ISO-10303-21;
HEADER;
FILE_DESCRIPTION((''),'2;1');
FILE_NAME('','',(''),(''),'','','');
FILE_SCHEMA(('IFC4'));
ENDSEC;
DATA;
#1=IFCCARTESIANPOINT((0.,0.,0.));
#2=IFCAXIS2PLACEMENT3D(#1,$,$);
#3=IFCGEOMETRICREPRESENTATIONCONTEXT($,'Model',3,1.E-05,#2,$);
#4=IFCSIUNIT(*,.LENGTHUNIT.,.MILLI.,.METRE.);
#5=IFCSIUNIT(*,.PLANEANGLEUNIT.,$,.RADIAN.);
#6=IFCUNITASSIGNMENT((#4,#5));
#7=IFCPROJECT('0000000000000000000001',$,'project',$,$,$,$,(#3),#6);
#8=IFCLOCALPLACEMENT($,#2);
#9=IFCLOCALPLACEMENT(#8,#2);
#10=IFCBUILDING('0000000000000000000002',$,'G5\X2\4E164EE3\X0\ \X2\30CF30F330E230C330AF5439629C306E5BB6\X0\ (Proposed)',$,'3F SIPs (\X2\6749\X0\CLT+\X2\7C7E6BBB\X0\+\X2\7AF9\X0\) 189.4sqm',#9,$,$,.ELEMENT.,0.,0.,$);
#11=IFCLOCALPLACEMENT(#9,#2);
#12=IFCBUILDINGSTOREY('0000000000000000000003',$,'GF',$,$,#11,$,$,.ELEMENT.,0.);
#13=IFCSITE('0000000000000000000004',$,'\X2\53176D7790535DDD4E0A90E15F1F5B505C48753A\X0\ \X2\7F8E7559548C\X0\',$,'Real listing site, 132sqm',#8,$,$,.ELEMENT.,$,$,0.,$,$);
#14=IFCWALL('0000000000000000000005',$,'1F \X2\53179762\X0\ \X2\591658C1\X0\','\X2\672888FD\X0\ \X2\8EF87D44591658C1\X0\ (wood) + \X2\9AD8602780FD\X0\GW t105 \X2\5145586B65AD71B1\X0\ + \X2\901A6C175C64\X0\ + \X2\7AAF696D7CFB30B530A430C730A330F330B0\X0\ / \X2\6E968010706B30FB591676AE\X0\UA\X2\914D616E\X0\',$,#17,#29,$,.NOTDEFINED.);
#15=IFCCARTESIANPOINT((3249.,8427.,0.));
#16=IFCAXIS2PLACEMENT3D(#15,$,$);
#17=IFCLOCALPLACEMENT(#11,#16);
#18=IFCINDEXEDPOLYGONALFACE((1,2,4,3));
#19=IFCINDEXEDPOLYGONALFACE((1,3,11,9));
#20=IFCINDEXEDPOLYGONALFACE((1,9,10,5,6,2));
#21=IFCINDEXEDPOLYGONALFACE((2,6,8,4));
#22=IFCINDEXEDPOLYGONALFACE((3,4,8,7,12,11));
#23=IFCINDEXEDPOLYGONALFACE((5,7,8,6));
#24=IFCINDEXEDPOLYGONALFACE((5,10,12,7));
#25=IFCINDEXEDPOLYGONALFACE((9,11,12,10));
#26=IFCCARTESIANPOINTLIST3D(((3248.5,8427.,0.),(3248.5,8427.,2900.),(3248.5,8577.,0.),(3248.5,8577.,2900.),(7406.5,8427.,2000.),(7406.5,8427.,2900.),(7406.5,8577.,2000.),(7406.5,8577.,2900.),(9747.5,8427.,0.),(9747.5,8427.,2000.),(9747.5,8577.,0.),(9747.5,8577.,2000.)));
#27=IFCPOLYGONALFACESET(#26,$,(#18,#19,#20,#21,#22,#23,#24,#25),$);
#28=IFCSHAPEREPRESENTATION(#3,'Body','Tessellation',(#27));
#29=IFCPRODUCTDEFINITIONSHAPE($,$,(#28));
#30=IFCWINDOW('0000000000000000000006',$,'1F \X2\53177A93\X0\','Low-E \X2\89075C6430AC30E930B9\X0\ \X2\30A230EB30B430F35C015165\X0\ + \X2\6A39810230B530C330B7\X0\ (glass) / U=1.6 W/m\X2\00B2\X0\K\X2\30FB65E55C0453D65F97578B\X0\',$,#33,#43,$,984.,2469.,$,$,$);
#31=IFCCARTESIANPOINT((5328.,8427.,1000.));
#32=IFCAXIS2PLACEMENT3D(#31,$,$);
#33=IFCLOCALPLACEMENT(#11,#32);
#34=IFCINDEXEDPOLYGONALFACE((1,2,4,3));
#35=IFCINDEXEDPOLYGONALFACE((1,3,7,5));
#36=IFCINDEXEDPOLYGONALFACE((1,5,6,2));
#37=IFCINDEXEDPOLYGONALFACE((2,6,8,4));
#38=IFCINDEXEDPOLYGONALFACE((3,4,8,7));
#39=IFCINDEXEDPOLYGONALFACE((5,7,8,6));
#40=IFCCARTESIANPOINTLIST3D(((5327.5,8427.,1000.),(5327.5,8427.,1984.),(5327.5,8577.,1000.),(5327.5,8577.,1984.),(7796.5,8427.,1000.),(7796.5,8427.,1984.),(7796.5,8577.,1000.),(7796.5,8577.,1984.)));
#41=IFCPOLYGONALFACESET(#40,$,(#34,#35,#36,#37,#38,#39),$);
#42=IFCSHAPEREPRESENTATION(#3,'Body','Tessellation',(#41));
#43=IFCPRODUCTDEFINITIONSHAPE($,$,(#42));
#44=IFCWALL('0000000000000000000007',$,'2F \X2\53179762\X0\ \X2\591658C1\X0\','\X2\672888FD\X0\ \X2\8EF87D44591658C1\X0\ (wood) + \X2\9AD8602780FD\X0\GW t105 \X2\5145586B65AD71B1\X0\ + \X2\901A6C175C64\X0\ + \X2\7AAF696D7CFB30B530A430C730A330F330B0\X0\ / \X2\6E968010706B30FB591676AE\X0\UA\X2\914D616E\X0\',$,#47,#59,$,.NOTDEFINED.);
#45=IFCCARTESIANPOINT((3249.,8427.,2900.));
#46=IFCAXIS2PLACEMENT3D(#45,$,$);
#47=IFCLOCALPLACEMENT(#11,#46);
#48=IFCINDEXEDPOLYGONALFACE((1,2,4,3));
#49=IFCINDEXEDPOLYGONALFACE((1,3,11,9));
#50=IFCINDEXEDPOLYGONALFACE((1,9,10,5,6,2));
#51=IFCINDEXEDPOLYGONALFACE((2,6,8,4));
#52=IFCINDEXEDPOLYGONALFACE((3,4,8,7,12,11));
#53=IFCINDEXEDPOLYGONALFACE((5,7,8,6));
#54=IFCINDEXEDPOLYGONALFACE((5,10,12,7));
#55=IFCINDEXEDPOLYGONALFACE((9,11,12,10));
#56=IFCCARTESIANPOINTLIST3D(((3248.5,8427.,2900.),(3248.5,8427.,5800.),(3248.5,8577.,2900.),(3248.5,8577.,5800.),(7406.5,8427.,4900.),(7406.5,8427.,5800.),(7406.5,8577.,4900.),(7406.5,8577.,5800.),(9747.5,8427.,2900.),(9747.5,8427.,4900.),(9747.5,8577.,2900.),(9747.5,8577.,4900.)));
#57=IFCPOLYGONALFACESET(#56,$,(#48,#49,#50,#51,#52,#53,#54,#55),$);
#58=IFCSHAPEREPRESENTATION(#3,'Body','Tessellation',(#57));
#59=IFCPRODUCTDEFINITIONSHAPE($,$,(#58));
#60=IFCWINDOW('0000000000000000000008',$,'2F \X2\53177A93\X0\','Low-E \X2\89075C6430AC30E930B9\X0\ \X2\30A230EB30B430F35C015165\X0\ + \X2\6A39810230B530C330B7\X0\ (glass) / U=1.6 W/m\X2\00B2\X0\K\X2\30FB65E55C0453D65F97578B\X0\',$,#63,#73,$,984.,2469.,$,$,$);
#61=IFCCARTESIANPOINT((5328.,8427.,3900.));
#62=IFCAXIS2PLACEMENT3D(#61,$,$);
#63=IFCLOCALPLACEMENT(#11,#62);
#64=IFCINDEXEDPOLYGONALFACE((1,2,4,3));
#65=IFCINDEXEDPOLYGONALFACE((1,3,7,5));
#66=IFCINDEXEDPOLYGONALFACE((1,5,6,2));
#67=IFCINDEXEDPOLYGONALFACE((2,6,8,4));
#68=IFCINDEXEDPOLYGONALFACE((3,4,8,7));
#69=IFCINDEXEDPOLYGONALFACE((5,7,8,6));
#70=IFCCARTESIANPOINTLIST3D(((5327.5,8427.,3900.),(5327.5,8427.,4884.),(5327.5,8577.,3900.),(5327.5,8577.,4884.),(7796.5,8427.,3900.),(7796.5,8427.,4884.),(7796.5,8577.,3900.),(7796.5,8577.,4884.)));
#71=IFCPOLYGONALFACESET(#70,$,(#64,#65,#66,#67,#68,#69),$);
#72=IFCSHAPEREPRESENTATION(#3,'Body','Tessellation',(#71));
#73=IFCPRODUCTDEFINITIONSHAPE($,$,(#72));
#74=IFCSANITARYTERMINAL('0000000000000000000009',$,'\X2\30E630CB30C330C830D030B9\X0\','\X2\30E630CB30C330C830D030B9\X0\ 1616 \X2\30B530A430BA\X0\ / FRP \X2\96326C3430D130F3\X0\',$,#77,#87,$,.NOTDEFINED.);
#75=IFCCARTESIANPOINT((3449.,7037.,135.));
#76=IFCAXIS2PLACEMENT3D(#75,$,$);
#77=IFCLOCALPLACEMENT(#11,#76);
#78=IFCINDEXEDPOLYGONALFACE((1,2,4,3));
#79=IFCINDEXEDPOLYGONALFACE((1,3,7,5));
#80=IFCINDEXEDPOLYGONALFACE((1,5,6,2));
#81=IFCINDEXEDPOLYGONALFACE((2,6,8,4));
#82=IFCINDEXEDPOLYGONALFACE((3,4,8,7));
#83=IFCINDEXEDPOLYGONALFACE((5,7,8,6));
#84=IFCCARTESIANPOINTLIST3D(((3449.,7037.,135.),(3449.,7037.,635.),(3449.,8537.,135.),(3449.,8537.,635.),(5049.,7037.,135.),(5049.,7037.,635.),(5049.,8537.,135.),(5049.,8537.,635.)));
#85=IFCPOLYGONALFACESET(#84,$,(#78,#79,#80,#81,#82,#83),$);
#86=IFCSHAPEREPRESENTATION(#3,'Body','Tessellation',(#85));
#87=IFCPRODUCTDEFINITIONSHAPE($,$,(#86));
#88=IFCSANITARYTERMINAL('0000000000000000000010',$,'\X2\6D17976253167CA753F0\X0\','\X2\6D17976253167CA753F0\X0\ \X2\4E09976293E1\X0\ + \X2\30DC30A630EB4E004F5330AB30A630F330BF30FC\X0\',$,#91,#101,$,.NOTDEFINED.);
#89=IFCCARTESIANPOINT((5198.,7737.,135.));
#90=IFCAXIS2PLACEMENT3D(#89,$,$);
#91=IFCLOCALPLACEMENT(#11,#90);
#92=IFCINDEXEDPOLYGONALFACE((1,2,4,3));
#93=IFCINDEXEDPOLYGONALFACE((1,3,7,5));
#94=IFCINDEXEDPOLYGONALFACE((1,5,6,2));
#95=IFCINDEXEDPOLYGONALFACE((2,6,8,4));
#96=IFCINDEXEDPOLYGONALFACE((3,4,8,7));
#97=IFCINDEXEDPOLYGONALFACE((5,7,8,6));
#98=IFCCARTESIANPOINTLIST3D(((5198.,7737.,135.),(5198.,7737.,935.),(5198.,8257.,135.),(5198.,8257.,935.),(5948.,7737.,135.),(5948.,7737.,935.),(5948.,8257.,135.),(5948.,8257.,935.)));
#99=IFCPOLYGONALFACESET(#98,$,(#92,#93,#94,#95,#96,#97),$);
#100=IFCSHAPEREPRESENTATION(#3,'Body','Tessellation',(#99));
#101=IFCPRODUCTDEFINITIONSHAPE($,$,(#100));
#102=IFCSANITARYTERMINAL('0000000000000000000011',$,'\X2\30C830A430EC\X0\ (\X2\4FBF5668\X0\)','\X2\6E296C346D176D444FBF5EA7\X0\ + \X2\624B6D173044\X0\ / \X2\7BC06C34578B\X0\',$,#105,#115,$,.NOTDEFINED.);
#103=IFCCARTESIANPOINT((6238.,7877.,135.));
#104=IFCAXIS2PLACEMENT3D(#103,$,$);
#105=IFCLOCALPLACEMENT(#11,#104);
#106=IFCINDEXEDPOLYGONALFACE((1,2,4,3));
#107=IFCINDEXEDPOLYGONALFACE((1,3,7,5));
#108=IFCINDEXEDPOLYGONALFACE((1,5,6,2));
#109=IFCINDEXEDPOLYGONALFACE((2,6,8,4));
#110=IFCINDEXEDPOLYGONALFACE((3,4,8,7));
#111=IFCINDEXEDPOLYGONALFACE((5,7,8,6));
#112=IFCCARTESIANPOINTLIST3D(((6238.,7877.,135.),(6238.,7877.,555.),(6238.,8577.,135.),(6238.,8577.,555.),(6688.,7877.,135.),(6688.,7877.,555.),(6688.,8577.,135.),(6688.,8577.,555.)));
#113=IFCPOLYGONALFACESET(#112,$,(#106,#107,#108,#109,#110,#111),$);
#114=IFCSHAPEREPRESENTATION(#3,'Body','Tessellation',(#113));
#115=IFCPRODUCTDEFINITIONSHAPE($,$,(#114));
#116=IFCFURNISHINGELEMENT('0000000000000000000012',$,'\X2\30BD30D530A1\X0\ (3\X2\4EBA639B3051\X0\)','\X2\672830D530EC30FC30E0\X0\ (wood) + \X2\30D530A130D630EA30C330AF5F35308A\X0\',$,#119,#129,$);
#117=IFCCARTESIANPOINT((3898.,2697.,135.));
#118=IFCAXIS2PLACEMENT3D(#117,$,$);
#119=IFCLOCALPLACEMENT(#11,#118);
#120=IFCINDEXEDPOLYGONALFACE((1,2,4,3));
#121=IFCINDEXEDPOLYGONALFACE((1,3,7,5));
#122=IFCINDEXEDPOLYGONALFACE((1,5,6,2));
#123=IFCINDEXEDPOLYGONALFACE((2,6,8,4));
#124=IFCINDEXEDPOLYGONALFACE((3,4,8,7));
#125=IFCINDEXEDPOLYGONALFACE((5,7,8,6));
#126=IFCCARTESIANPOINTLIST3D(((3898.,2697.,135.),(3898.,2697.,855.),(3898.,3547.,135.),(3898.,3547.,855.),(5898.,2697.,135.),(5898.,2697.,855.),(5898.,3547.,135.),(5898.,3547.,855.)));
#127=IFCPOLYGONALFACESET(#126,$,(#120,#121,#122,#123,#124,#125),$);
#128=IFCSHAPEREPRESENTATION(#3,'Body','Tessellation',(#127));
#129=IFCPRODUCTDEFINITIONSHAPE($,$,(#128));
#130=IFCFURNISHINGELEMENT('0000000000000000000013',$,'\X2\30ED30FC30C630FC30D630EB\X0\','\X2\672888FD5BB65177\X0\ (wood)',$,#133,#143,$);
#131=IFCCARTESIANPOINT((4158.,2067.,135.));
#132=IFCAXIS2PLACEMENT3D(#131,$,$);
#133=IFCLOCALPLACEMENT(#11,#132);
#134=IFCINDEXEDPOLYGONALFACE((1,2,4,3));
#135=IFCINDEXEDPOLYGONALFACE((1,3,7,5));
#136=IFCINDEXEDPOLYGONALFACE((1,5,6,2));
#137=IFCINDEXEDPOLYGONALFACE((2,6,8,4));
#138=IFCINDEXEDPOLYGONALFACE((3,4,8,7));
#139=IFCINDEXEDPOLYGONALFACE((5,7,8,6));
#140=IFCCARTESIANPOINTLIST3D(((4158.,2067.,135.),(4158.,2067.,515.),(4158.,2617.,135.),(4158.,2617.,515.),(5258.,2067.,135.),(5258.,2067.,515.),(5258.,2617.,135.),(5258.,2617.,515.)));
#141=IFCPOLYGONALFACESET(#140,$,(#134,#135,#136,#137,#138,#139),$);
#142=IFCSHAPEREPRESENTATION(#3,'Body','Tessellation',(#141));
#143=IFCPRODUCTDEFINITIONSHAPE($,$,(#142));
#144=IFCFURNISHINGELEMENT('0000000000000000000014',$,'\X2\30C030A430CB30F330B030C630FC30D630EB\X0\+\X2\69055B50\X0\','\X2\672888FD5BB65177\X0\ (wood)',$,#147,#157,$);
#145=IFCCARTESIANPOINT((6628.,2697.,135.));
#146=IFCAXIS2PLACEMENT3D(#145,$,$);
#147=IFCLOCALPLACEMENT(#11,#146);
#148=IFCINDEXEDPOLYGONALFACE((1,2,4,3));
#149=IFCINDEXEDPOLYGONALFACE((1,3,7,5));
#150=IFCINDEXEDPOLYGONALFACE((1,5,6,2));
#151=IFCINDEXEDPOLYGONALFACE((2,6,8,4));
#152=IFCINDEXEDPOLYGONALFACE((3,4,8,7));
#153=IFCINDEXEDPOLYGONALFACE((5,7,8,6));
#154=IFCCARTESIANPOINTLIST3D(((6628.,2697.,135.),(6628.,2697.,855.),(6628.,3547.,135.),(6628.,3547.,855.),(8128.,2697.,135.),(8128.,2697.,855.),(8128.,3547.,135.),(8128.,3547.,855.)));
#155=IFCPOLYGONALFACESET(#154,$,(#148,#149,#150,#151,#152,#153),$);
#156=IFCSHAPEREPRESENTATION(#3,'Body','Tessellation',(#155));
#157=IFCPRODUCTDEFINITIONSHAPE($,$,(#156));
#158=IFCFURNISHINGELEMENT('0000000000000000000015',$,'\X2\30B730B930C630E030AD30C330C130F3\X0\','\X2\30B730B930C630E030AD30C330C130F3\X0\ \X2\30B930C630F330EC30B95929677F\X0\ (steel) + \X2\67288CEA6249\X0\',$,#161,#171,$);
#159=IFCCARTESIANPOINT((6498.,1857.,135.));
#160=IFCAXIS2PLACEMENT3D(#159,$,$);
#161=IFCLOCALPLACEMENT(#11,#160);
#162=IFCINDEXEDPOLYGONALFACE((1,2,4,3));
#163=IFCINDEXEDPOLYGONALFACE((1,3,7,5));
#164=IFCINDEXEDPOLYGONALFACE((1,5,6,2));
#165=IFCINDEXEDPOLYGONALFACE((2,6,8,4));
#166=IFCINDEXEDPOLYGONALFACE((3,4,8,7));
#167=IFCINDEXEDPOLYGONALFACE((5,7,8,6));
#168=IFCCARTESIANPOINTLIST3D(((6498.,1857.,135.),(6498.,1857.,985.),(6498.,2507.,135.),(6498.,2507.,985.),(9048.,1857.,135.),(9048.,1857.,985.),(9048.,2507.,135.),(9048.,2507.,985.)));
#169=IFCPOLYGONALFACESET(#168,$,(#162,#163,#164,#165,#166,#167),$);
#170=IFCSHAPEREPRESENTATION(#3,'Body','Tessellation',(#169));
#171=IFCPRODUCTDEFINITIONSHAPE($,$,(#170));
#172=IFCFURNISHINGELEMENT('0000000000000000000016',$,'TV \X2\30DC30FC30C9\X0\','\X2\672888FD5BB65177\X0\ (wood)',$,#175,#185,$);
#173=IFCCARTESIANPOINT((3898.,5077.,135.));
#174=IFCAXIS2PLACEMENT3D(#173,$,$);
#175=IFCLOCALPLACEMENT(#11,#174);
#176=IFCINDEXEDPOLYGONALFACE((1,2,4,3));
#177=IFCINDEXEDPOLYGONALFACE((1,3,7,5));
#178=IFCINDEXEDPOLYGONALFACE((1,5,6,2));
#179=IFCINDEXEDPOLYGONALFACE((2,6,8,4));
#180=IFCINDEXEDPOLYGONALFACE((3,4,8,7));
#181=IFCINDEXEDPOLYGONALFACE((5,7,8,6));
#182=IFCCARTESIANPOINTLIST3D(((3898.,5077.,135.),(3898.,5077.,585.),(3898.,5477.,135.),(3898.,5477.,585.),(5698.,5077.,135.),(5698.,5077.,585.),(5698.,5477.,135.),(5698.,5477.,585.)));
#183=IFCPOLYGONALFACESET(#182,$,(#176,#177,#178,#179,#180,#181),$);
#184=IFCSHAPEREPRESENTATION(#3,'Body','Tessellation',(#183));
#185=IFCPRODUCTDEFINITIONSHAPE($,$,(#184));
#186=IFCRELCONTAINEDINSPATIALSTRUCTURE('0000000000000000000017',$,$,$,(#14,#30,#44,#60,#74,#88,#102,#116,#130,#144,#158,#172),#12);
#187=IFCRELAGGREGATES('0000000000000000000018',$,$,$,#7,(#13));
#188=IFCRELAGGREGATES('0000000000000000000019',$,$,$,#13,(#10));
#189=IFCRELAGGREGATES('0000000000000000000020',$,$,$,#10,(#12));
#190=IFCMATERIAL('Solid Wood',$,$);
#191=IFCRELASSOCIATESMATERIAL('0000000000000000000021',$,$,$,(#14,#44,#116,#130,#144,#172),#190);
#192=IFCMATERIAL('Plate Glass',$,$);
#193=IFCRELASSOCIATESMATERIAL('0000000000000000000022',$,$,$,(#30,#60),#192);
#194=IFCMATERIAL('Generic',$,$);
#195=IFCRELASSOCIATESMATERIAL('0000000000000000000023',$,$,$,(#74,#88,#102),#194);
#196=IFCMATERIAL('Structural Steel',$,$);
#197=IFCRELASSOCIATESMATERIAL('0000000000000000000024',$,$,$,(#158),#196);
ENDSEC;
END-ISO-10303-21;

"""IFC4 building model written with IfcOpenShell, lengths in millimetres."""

from ifc_helpers import new_model, si_unit, frame, frame_2d, origin, place, context, project, spatial, rectangle, extrude, material, element, fill, save


model = new_model("IFC4")

# Units and contexts
model_context = context("Model", 3, precision=1e-05, world=origin())
ifc_project = project(units=[si_unit("LENGTHUNIT", "METRE", prefix="MILLI"), si_unit("PLANEANGLEUNIT", "RADIAN")], contexts=[model_context])

# Site, building, storey
site_placement = place(None, origin())
site = spatial("IfcSite", under=ifc_project, at=site_placement, Name="北海道川上郡弟子屈町 美留和", ObjectType="Real listing site, 132sqm", CompositionType="ELEMENT", RefElevation=0.0)
building_placement = place(site_placement, origin())
building = spatial("IfcBuilding", under=site, at=building_placement, Name="G5世代 ハンモック吹抜の家 (Proposed)", ObjectType="3F SIPs (杉CLT+籾殻+竹) 189.4sqm", CompositionType="ELEMENT", ElevationOfRefHeight=0.0, ElevationOfTerrain=0.0)
storey_placement = place(building_placement, origin())
storey = spatial("IfcBuildingStorey", under=building, at=storey_placement, Name="GF", CompositionType="ELEMENT", Elevation=0.0)

# Wall, opening, window
ifc_material_1 = material(Name="Solid Wood")
wall_1_placement = place(storey_placement, frame((3249.0, 8427.0, 0.0)))
wall_1 = element("IfcWall", 1, at=wall_1_placement, inside=storey, material=ifc_material_1, Name="1F 北面 外壁", Description="木製 軸組外壁 (wood) + 高性能GW t105 充填断熱 + 通気層 + 窯業系サイディング / 準耐火・外皮UA配慮", PredefinedType="NOTDEFINED", context=model_context, shape_type="SweptSolid", body=[
    extrude(rectangle(XDim=6499.0, YDim=150.0, at=frame_2d((3249.0, 75.0))), frame((3249.0, 8427.0, 0.0)), (0.0, 0.0, 1.0), 2900.0),
])
opening_1_placement = place(storey_placement, frame((5328.0, 8427.0, 1000.0)))
opening_1 = element("IfcOpeningElement", 2, at=opening_1_placement, cuts=wall_1, PredefinedType="NOTDEFINED", context=model_context, shape_type="SweptSolid", body=[
    extrude(rectangle(XDim=2469.0, YDim=150.0, at=frame_2d((1234.0, 75.0))), frame((5328.0, 8427.0, 1000.0)), (0.0, 0.0, 1.0), 984.0),
])
ifc_material_2 = material(Name="Plate Glass")
window_1_placement = place(storey_placement, frame((5328.0, 8427.0, 1000.0)))
window_1 = element("IfcWindow", 3, at=window_1_placement, inside=storey, material=ifc_material_2, Name="1F 北窓", Description="Low-E 複層ガラス アルゴン封入 + 樹脂サッシ (glass) / U=1.6 W/m²K・日射取得型", OverallHeight=984.0, OverallWidth=2469.0, context=model_context, shape_type="SweptSolid", body=[
    extrude(rectangle(XDim=2469.0, YDim=150.0, at=frame_2d((1234.0, 75.0))), frame((5328.0, 8427.0, 1000.0)), (0.0, 0.0, 1.0), 984.0),
])
fill(opening_1, window_1)

# Wall, opening, window
wall_2_placement = place(storey_placement, frame((3249.0, 8427.0, 2900.0)))
wall_2 = element("IfcWall", 4, at=wall_2_placement, inside=storey, material=ifc_material_1, Name="2F 北面 外壁", Description="木製 軸組外壁 (wood) + 高性能GW t105 充填断熱 + 通気層 + 窯業系サイディング / 準耐火・外皮UA配慮", PredefinedType="NOTDEFINED", context=model_context, shape_type="SweptSolid", body=[
    extrude(rectangle(XDim=6499.0, YDim=150.0, at=frame_2d((3249.0, 75.0))), frame((3249.0, 8427.0, 2900.0)), (0.0, 0.0, 1.0), 2900.0),
])
opening_2_placement = place(storey_placement, frame((5328.0, 8427.0, 3900.0)))
opening_2 = element("IfcOpeningElement", 5, at=opening_2_placement, cuts=wall_2, PredefinedType="NOTDEFINED", context=model_context, shape_type="SweptSolid", body=[
    extrude(rectangle(XDim=2469.0, YDim=150.0, at=frame_2d((1234.0, 75.0))), frame((5328.0, 8427.0, 3900.0)), (0.0, 0.0, 1.0), 984.0),
])
window_2_placement = place(storey_placement, frame((5328.0, 8427.0, 3900.0)))
window_2 = element("IfcWindow", 6, at=window_2_placement, inside=storey, material=ifc_material_2, Name="2F 北窓", Description="Low-E 複層ガラス アルゴン封入 + 樹脂サッシ (glass) / U=1.6 W/m²K・日射取得型", OverallHeight=984.0, OverallWidth=2469.0, context=model_context, shape_type="SweptSolid", body=[
    extrude(rectangle(XDim=2469.0, YDim=150.0, at=frame_2d((1234.0, 75.0))), frame((5328.0, 8427.0, 3900.0)), (0.0, 0.0, 1.0), 984.0),
])
fill(opening_2, window_2)

# Sanitary terminals
ifc_material_3 = material(Name="Generic")
sanitary_terminal_1_placement = place(storey_placement, frame((3449.0, 7037.0, 135.0)))
element("IfcSanitaryTerminal", 7, at=sanitary_terminal_1_placement, inside=storey, material=ifc_material_3, Name="ユニットバス", Description="ユニットバス 1616 サイズ / FRP 防水パン", PredefinedType="NOTDEFINED", context=model_context, shape_type="SweptSolid", body=[
    extrude(rectangle(XDim=1600.0, YDim=1500.0, at=frame_2d((800.0, 750.0))), frame((3449.0, 7037.0, 135.0)), (0.0, 0.0, 1.0), 500.0),
])
sanitary_terminal_2_placement = place(storey_placement, frame((5198.0, 7737.0, 135.0)))
element("IfcSanitaryTerminal", 8, at=sanitary_terminal_2_placement, inside=storey, material=ifc_material_3, Name="洗面化粧台", Description="洗面化粧台 三面鏡 + ボウル一体カウンター", PredefinedType="NOTDEFINED", context=model_context, shape_type="SweptSolid", body=[
    extrude(rectangle(XDim=750.0, YDim=520.0, at=frame_2d((375.0, 260.0))), frame((5198.0, 7737.0, 135.0)), (0.0, 0.0, 1.0), 800.0),
])
sanitary_terminal_3_placement = place(storey_placement, frame((6238.0, 7877.0, 135.0)))
element("IfcSanitaryTerminal", 9, at=sanitary_terminal_3_placement, inside=storey, material=ifc_material_3, Name="トイレ (便器)", Description="温水洗浄便座 + 手洗い / 節水型", PredefinedType="NOTDEFINED", context=model_context, shape_type="SweptSolid", body=[
    extrude(rectangle(XDim=450.0, YDim=700.0, at=frame_2d((225.0, 350.0))), frame((6238.0, 7877.0, 135.0)), (0.0, 0.0, 1.0), 420.0),
])

# Furnishing elements
furnishing_1_placement = place(storey_placement, frame((3898.0, 2697.0, 135.0)))
element("IfcFurnishingElement", 10, at=furnishing_1_placement, inside=storey, material=ifc_material_1, Name="ソファ (3人掛け)", Description="木フレーム (wood) + ファブリック張り", context=model_context, shape_type="SweptSolid", body=[
    extrude(rectangle(XDim=2000.0, YDim=850.0, at=frame_2d((1000.0, 425.0))), frame((3898.0, 2697.0, 135.0)), (0.0, 0.0, 1.0), 720.0),
])
furnishing_2_placement = place(storey_placement, frame((4158.0, 2067.0, 135.0)))
element("IfcFurnishingElement", 11, at=furnishing_2_placement, inside=storey, material=ifc_material_1, Name="ローテーブル", Description="木製家具 (wood)", context=model_context, shape_type="SweptSolid", body=[
    extrude(rectangle(XDim=1100.0, YDim=550.0, at=frame_2d((550.0, 275.0))), frame((4158.0, 2067.0, 135.0)), (0.0, 0.0, 1.0), 380.0),
])
furnishing_3_placement = place(storey_placement, frame((6628.0, 2697.0, 135.0)))
element("IfcFurnishingElement", 12, at=furnishing_3_placement, inside=storey, material=ifc_material_1, Name="ダイニングテーブル+椅子", Description="木製家具 (wood)", context=model_context, shape_type="SweptSolid", body=[
    extrude(rectangle(XDim=1500.0, YDim=850.0, at=frame_2d((750.0, 425.0))), frame((6628.0, 2697.0, 135.0)), (0.0, 0.0, 1.0), 720.0),
])
ifc_material_4 = material(Name="Structural Steel")
furnishing_4_placement = place(storey_placement, frame((6498.0, 1857.0, 135.0)))
element("IfcFurnishingElement", 13, at=furnishing_4_placement, inside=storey, material=ifc_material_4, Name="システムキッチン", Description="システムキッチン ステンレス天板 (steel) + 木質扉", context=model_context, shape_type="SweptSolid", body=[
    extrude(rectangle(XDim=2550.0, YDim=650.0, at=frame_2d((1275.0, 325.0))), frame((6498.0, 1857.0, 135.0)), (0.0, 0.0, 1.0), 850.0),
])
furnishing_5_placement = place(storey_placement, frame((3898.0, 5077.0, 135.0)))
element("IfcFurnishingElement", 14, at=furnishing_5_placement, inside=storey, material=ifc_material_1, Name="TV ボード", Description="木製家具 (wood)", context=model_context, shape_type="SweptSolid", body=[
    extrude(rectangle(XDim=1800.0, YDim=400.0, at=frame_2d((900.0, 200.0))), frame((3898.0, 5077.0, 135.0)), (0.0, 0.0, 1.0), 450.0),
])

save(model, "model.ifc")
